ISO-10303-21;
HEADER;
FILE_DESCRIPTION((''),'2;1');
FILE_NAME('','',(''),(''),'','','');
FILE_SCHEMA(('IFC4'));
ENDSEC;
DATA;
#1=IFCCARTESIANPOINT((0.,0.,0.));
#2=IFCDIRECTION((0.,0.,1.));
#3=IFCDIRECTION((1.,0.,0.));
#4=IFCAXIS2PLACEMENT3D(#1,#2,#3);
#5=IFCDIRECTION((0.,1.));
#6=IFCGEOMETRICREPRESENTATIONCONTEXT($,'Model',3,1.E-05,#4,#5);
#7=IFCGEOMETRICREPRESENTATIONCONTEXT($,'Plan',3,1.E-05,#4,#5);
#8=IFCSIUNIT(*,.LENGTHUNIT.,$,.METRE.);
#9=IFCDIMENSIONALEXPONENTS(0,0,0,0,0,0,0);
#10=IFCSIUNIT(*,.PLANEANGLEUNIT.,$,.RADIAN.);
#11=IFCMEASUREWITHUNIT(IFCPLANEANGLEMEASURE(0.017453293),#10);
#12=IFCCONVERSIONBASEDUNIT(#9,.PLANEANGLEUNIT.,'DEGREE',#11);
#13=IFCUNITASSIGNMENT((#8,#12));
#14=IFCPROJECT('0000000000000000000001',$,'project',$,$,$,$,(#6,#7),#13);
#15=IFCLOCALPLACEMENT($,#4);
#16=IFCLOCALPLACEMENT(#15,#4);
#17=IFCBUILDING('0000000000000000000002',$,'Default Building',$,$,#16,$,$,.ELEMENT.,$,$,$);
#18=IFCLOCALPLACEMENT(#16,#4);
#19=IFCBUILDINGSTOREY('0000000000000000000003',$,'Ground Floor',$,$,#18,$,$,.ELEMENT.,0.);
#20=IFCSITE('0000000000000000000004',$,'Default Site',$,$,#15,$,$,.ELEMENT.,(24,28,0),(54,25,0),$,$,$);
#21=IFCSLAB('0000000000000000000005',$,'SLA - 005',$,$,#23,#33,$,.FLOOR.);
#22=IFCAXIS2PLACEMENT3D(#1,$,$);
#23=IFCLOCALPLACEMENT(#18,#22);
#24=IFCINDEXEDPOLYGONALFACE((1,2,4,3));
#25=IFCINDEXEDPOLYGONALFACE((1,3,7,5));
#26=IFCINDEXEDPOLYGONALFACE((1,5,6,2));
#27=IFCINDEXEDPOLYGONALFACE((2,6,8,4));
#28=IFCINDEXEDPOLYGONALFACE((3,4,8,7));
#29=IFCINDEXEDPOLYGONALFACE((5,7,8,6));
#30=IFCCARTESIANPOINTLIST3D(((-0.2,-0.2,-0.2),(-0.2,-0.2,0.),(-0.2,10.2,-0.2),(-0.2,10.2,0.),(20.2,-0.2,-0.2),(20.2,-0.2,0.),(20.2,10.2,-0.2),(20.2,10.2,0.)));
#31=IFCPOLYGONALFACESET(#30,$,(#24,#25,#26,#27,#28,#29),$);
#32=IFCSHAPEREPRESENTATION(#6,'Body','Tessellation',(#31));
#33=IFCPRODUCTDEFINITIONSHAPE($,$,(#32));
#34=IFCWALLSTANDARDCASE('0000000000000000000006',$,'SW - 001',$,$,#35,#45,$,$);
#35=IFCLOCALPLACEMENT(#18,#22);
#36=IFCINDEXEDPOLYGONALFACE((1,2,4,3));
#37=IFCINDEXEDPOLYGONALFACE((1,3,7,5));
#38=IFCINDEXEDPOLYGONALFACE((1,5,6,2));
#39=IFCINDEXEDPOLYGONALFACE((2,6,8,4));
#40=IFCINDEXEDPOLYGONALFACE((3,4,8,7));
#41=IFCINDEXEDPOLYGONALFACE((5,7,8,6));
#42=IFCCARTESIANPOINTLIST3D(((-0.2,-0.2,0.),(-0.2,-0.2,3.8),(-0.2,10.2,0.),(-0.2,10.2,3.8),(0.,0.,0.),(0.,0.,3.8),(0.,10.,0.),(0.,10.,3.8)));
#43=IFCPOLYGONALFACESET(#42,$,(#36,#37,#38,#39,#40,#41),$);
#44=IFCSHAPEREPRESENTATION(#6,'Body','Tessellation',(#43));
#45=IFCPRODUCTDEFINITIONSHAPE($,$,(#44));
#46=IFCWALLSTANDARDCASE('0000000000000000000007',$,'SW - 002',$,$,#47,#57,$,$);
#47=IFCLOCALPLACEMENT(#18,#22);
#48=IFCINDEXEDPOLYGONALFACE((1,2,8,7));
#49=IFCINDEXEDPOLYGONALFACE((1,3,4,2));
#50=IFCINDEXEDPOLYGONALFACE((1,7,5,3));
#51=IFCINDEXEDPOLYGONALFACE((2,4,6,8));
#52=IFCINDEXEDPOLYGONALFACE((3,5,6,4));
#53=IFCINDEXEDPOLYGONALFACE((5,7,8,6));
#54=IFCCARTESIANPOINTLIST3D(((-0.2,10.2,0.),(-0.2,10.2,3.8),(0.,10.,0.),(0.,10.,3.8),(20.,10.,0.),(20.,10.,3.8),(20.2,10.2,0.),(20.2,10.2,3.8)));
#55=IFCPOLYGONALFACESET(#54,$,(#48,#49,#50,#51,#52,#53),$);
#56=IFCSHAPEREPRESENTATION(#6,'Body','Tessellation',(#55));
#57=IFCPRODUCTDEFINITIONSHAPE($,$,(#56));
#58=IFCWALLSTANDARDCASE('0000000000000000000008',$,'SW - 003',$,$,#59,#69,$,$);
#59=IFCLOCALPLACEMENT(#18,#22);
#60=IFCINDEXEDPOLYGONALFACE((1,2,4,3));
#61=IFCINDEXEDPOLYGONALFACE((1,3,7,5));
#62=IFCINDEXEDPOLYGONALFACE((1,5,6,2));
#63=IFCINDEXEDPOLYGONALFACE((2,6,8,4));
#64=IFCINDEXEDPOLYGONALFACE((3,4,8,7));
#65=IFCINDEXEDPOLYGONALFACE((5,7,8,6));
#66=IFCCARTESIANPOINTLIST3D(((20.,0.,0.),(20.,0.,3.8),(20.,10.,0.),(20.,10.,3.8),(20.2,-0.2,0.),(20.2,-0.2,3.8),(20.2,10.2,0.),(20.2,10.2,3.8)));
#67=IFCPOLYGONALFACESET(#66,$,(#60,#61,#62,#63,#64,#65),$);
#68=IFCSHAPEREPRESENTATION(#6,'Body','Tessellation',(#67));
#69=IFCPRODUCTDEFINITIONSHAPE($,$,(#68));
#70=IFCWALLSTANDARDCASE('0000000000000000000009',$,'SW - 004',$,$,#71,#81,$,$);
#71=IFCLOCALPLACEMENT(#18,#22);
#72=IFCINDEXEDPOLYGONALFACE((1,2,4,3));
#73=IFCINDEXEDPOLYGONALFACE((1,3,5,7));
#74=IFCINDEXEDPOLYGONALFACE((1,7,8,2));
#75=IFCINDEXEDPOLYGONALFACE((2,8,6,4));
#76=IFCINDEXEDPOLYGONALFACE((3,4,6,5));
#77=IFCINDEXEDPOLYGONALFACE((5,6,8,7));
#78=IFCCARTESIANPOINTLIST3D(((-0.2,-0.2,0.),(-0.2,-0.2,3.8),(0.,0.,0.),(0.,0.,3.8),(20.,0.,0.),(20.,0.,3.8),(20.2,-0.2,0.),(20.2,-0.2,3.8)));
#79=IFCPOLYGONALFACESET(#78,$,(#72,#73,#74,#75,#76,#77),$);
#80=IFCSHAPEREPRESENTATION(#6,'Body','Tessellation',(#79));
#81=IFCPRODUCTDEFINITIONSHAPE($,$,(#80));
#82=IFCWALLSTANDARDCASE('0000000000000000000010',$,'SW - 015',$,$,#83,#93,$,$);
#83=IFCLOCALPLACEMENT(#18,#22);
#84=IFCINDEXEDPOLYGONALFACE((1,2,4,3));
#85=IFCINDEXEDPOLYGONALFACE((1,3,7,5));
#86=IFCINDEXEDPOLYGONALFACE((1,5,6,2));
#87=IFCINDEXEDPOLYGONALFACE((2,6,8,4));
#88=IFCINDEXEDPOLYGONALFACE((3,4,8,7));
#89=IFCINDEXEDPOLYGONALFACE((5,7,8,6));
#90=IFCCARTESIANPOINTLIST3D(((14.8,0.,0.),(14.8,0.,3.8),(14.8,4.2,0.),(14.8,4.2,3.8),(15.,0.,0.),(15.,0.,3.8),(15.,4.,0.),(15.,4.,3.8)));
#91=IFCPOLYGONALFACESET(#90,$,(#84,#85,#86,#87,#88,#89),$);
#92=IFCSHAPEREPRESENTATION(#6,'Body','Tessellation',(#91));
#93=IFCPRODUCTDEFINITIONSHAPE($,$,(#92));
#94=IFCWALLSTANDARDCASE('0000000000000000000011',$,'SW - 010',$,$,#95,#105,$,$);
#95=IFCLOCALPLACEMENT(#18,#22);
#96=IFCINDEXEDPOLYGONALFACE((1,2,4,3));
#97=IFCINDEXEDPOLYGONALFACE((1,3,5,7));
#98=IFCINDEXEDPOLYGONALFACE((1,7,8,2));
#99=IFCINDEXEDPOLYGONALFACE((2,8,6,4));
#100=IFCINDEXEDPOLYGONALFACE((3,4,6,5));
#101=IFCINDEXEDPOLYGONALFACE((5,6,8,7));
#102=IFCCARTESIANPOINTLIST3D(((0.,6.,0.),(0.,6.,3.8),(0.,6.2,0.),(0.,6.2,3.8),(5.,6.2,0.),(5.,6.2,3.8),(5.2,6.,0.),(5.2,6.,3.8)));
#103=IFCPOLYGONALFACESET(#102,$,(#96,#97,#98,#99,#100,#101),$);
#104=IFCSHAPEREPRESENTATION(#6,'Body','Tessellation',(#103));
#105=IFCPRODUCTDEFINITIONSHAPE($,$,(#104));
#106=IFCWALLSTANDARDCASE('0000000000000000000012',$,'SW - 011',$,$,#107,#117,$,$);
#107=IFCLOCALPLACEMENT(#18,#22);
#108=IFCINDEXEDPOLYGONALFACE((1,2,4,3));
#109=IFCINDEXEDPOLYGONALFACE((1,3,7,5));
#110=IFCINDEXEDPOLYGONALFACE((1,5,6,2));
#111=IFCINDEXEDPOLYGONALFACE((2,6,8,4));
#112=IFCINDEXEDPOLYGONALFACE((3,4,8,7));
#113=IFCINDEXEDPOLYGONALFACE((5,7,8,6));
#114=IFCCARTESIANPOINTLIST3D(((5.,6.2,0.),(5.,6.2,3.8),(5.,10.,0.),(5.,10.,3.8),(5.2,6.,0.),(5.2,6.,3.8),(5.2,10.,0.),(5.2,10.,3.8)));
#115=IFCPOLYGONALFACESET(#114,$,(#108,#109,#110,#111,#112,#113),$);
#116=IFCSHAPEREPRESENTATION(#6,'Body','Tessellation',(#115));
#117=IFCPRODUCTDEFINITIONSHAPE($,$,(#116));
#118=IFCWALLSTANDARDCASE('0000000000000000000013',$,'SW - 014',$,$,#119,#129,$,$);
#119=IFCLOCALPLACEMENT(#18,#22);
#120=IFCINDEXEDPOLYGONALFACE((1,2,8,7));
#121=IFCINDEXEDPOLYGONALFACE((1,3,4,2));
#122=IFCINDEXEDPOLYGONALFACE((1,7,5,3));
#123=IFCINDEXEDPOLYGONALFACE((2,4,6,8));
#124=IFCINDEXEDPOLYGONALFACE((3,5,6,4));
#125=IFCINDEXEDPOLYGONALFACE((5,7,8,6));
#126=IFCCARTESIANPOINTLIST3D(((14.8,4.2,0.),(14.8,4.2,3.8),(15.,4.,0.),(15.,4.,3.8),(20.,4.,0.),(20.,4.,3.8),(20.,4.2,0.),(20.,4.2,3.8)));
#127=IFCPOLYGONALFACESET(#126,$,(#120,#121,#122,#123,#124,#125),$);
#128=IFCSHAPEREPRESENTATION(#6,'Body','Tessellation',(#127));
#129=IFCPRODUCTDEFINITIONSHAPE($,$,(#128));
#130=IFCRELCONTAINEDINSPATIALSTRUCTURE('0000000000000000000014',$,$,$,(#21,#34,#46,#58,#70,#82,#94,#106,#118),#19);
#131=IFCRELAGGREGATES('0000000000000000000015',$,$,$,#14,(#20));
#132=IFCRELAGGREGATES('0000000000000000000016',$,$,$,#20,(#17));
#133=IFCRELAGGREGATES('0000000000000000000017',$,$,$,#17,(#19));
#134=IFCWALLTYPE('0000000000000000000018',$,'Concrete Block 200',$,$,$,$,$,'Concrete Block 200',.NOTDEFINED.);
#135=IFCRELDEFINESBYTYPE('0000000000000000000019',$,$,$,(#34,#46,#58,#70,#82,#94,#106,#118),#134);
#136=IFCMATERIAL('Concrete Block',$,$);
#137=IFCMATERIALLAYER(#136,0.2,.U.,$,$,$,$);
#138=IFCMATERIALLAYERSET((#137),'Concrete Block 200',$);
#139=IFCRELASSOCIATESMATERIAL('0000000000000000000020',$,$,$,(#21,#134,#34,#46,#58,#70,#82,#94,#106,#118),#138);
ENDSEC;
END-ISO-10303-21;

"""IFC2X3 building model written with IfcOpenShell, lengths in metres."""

from ifc_helpers import new_model, entity, si_unit, converted_unit, direction, frame, origin_with_axes, place, context, project, spatial, polyline, outline, extrude, material, layer, layer_set, layer_usage, type_object, element, save


model = new_model("IFC2X3")

# Units and contexts
model_context = context("Model", 3, precision=1e-05, world=origin_with_axes(), true_north=direction((0.0, 1.0)))
plan_context = context("Plan", 3, precision=1e-05, world=origin_with_axes(), true_north=direction((0.0, 1.0)))
ifc_project = project(units=[si_unit("LENGTHUNIT", "METRE"), converted_unit("PLANEANGLEUNIT", "DEGREE", entity("IfcPlaneAngleMeasure", 0.017453293), si_unit("PLANEANGLEUNIT", "RADIAN"), dimensions=[0, 0, 0, 0, 0, 0, 0])], contexts=[model_context, plan_context])

# Site, building, storey
site_placement = place(None, origin_with_axes())
site = spatial("IfcSite", under=ifc_project, at=site_placement, Name="Default Site", CompositionType="ELEMENT", RefLatitude=(24, 28, 0), RefLongitude=(54, 25, 0))
building_placement = place(site_placement, origin_with_axes())
building = spatial("IfcBuilding", under=site, at=building_placement, Name="Default Building", CompositionType="ELEMENT")
storey_placement = place(building_placement, origin_with_axes())
storey = spatial("IfcBuildingStorey", under=building, at=storey_placement, Name="Ground Floor", CompositionType="ELEMENT", Elevation=0.0)

# Slab
ifc_material = material(Name="Concrete Block")
ifc_layer = layer(ifc_material, 0.2, ventilated="UNKNOWN")
ifc_layer_set = layer_set([ifc_layer], Name="Concrete Block 200")
ifc_layer_usage_1 = layer_usage(ifc_layer_set, "AXIS3", "NEGATIVE", 0.2)
slab_placement = place(storey_placement, frame((-0.2, 10.2, -0.2), z_axis=(0.0, 0.0, 1.0), x_axis=(1.0, 0.0, 0.0)))
element("IfcSlab", 1, at=slab_placement, inside=storey, material=ifc_layer_usage_1, Name="SLA - 005", PredefinedType="FLOOR", context=model_context, shape_type="SweptSolid", body=[
    extrude(outline(polyline([(0.0, 0.0), (20.4, 0.0), (20.4, -10.4), (0.0, -10.4), (0.0, 0.0)])), origin_with_axes(), (0.0, 0.0, 1.0), 0.2),
])

# Walls
ifc_layer_usage_2 = layer_usage(ifc_layer_set, "AXIS2", "POSITIVE", 0.0)
wall_type = type_object("IfcWallType", Name="Concrete Block 200", ElementType="Concrete Block 200", PredefinedType="NOTDEFINED", material=ifc_layer_set)
wall_1_placement = place(storey_placement, frame((0.0, 0.0, 0.0), z_axis=(0.0, 0.0, 1.0), x_axis=(0.0, 1.0, 0.0)))
element("IfcWallStandardCase", 2, at=wall_1_placement, inside=storey, type_object=wall_type, material=ifc_layer_usage_2, Name="SW - 001", context=model_context, shape_type="SweptSolid", body=[
    extrude(outline(polyline([(0.0, 0.0), (10.0, 0.0), (10.2, 0.2), (-0.2, 0.2), (0.0, 0.0)])), origin_with_axes(), (0.0, 0.0, 1.0), 3.8),
])
ifc_layer_usage_3 = layer_usage(ifc_layer_set, "AXIS2", "POSITIVE", 0.0)
wall_2_placement = place(storey_placement, frame((0.0, 10.0, 0.0), z_axis=(0.0, 0.0, 1.0), x_axis=(1.0, 0.0, 0.0)))
element("IfcWallStandardCase", 3, at=wall_2_placement, inside=storey, type_object=wall_type, material=ifc_layer_usage_3, Name="SW - 002", context=model_context, shape_type="SweptSolid", body=[
    extrude(outline(polyline([(0.0, 0.0), (20.0, 0.0), (20.2, 0.2), (-0.2, 0.2), (0.0, 0.0)])), origin_with_axes(), (0.0, 0.0, 1.0), 3.8),
])
ifc_layer_usage_4 = layer_usage(ifc_layer_set, "AXIS2", "POSITIVE", 0.0)
wall_3_placement = place(storey_placement, frame((20.0, 10.0, 0.0), z_axis=(0.0, 0.0, 1.0), x_axis=(0.0, -1.0, 0.0)))
element("IfcWallStandardCase", 4, at=wall_3_placement, inside=storey, type_object=wall_type, material=ifc_layer_usage_4, Name="SW - 003", context=model_context, shape_type="SweptSolid", body=[
    extrude(outline(polyline([(0.0, 0.0), (10.0, 0.0), (10.2, 0.2), (-0.2, 0.2), (0.0, 0.0)])), origin_with_axes(), (0.0, 0.0, 1.0), 3.8),
])
ifc_layer_usage_5 = layer_usage(ifc_layer_set, "AXIS2", "POSITIVE", 0.0)
wall_4_placement = place(storey_placement, frame((20.0, 0.0, 0.0), z_axis=(0.0, 0.0, 1.0), x_axis=(-1.0, 0.0, 0.0)))
element("IfcWallStandardCase", 5, at=wall_4_placement, inside=storey, type_object=wall_type, material=ifc_layer_usage_5, Name="SW - 004", context=model_context, shape_type="SweptSolid", body=[
    extrude(outline(polyline([(0.0, 0.0), (20.0, 0.0), (20.2, 0.2), (-0.2, 0.2), (0.0, 0.0)])), origin_with_axes(), (0.0, 0.0, 1.0), 3.8),
])
ifc_layer_usage_6 = layer_usage(ifc_layer_set, "AXIS2", "NEGATIVE", 0.0)
wall_5_placement = place(storey_placement, frame((15.0, 4.0, 0.0), z_axis=(0.0, 0.0, 1.0), x_axis=(0.0, -1.0, 0.0)))
element("IfcWallStandardCase", 6, at=wall_5_placement, inside=storey, type_object=wall_type, material=ifc_layer_usage_6, Name="SW - 015", context=model_context, shape_type="SweptSolid", body=[
    extrude(outline(polyline([(-0.2, -0.2), (4.0, -0.2), (4.0, 0.0), (0.0, 0.0), (-0.2, -0.2)])), origin_with_axes(), (0.0, 0.0, 1.0), 3.8),
])
ifc_layer_usage_7 = layer_usage(ifc_layer_set, "AXIS2", "NEGATIVE", 0.0)
wall_6_placement = place(storey_placement, frame((0.0, 6.2, 0.0), z_axis=(0.0, 0.0, 1.0), x_axis=(1.0, 0.0, 0.0)))
element("IfcWallStandardCase", 7, at=wall_6_placement, inside=storey, type_object=wall_type, material=ifc_layer_usage_7, Name="SW - 010", context=model_context, shape_type="SweptSolid", body=[
    extrude(outline(polyline([(0.0, -0.2), (5.2, -0.2), (5.0, 0.0), (0.0, 0.0), (0.0, -0.2)])), origin_with_axes(), (0.0, 0.0, 1.0), 3.8),
])
ifc_layer_usage_8 = layer_usage(ifc_layer_set, "AXIS2", "POSITIVE", 0.0)
wall_7_placement = place(storey_placement, frame((5.0, 10.0, 0.0), z_axis=(0.0, 0.0, 1.0), x_axis=(0.0, -1.0, 0.0)))
element("IfcWallStandardCase", 8, at=wall_7_placement, inside=storey, type_object=wall_type, material=ifc_layer_usage_8, Name="SW - 011", context=model_context, shape_type="SweptSolid", body=[
    extrude(outline(polyline([(0.0, 0.0), (3.8, 0.0), (4.0, 0.2), (0.0, 0.2), (0.0, 0.0)])), origin_with_axes(), (0.0, 0.0, 1.0), 3.8),
])
ifc_layer_usage_9 = layer_usage(ifc_layer_set, "AXIS2", "NEGATIVE", 0.0)
wall_8_placement = place(storey_placement, frame((20.0, 4.0, 0.0), z_axis=(0.0, 0.0, 1.0), x_axis=(-1.0, 0.0, 0.0)))
element("IfcWallStandardCase", 9, at=wall_8_placement, inside=storey, type_object=wall_type, material=ifc_layer_usage_9, Name="SW - 014", context=model_context, shape_type="SweptSolid", body=[
    extrude(outline(polyline([(0.0, -0.2), (5.2, -0.2), (5.0, 0.0), (0.0, 0.0), (0.0, -0.2)])), origin_with_axes(), (0.0, 0.0, 1.0), 3.8),
])

save(model, "model.ifc")
